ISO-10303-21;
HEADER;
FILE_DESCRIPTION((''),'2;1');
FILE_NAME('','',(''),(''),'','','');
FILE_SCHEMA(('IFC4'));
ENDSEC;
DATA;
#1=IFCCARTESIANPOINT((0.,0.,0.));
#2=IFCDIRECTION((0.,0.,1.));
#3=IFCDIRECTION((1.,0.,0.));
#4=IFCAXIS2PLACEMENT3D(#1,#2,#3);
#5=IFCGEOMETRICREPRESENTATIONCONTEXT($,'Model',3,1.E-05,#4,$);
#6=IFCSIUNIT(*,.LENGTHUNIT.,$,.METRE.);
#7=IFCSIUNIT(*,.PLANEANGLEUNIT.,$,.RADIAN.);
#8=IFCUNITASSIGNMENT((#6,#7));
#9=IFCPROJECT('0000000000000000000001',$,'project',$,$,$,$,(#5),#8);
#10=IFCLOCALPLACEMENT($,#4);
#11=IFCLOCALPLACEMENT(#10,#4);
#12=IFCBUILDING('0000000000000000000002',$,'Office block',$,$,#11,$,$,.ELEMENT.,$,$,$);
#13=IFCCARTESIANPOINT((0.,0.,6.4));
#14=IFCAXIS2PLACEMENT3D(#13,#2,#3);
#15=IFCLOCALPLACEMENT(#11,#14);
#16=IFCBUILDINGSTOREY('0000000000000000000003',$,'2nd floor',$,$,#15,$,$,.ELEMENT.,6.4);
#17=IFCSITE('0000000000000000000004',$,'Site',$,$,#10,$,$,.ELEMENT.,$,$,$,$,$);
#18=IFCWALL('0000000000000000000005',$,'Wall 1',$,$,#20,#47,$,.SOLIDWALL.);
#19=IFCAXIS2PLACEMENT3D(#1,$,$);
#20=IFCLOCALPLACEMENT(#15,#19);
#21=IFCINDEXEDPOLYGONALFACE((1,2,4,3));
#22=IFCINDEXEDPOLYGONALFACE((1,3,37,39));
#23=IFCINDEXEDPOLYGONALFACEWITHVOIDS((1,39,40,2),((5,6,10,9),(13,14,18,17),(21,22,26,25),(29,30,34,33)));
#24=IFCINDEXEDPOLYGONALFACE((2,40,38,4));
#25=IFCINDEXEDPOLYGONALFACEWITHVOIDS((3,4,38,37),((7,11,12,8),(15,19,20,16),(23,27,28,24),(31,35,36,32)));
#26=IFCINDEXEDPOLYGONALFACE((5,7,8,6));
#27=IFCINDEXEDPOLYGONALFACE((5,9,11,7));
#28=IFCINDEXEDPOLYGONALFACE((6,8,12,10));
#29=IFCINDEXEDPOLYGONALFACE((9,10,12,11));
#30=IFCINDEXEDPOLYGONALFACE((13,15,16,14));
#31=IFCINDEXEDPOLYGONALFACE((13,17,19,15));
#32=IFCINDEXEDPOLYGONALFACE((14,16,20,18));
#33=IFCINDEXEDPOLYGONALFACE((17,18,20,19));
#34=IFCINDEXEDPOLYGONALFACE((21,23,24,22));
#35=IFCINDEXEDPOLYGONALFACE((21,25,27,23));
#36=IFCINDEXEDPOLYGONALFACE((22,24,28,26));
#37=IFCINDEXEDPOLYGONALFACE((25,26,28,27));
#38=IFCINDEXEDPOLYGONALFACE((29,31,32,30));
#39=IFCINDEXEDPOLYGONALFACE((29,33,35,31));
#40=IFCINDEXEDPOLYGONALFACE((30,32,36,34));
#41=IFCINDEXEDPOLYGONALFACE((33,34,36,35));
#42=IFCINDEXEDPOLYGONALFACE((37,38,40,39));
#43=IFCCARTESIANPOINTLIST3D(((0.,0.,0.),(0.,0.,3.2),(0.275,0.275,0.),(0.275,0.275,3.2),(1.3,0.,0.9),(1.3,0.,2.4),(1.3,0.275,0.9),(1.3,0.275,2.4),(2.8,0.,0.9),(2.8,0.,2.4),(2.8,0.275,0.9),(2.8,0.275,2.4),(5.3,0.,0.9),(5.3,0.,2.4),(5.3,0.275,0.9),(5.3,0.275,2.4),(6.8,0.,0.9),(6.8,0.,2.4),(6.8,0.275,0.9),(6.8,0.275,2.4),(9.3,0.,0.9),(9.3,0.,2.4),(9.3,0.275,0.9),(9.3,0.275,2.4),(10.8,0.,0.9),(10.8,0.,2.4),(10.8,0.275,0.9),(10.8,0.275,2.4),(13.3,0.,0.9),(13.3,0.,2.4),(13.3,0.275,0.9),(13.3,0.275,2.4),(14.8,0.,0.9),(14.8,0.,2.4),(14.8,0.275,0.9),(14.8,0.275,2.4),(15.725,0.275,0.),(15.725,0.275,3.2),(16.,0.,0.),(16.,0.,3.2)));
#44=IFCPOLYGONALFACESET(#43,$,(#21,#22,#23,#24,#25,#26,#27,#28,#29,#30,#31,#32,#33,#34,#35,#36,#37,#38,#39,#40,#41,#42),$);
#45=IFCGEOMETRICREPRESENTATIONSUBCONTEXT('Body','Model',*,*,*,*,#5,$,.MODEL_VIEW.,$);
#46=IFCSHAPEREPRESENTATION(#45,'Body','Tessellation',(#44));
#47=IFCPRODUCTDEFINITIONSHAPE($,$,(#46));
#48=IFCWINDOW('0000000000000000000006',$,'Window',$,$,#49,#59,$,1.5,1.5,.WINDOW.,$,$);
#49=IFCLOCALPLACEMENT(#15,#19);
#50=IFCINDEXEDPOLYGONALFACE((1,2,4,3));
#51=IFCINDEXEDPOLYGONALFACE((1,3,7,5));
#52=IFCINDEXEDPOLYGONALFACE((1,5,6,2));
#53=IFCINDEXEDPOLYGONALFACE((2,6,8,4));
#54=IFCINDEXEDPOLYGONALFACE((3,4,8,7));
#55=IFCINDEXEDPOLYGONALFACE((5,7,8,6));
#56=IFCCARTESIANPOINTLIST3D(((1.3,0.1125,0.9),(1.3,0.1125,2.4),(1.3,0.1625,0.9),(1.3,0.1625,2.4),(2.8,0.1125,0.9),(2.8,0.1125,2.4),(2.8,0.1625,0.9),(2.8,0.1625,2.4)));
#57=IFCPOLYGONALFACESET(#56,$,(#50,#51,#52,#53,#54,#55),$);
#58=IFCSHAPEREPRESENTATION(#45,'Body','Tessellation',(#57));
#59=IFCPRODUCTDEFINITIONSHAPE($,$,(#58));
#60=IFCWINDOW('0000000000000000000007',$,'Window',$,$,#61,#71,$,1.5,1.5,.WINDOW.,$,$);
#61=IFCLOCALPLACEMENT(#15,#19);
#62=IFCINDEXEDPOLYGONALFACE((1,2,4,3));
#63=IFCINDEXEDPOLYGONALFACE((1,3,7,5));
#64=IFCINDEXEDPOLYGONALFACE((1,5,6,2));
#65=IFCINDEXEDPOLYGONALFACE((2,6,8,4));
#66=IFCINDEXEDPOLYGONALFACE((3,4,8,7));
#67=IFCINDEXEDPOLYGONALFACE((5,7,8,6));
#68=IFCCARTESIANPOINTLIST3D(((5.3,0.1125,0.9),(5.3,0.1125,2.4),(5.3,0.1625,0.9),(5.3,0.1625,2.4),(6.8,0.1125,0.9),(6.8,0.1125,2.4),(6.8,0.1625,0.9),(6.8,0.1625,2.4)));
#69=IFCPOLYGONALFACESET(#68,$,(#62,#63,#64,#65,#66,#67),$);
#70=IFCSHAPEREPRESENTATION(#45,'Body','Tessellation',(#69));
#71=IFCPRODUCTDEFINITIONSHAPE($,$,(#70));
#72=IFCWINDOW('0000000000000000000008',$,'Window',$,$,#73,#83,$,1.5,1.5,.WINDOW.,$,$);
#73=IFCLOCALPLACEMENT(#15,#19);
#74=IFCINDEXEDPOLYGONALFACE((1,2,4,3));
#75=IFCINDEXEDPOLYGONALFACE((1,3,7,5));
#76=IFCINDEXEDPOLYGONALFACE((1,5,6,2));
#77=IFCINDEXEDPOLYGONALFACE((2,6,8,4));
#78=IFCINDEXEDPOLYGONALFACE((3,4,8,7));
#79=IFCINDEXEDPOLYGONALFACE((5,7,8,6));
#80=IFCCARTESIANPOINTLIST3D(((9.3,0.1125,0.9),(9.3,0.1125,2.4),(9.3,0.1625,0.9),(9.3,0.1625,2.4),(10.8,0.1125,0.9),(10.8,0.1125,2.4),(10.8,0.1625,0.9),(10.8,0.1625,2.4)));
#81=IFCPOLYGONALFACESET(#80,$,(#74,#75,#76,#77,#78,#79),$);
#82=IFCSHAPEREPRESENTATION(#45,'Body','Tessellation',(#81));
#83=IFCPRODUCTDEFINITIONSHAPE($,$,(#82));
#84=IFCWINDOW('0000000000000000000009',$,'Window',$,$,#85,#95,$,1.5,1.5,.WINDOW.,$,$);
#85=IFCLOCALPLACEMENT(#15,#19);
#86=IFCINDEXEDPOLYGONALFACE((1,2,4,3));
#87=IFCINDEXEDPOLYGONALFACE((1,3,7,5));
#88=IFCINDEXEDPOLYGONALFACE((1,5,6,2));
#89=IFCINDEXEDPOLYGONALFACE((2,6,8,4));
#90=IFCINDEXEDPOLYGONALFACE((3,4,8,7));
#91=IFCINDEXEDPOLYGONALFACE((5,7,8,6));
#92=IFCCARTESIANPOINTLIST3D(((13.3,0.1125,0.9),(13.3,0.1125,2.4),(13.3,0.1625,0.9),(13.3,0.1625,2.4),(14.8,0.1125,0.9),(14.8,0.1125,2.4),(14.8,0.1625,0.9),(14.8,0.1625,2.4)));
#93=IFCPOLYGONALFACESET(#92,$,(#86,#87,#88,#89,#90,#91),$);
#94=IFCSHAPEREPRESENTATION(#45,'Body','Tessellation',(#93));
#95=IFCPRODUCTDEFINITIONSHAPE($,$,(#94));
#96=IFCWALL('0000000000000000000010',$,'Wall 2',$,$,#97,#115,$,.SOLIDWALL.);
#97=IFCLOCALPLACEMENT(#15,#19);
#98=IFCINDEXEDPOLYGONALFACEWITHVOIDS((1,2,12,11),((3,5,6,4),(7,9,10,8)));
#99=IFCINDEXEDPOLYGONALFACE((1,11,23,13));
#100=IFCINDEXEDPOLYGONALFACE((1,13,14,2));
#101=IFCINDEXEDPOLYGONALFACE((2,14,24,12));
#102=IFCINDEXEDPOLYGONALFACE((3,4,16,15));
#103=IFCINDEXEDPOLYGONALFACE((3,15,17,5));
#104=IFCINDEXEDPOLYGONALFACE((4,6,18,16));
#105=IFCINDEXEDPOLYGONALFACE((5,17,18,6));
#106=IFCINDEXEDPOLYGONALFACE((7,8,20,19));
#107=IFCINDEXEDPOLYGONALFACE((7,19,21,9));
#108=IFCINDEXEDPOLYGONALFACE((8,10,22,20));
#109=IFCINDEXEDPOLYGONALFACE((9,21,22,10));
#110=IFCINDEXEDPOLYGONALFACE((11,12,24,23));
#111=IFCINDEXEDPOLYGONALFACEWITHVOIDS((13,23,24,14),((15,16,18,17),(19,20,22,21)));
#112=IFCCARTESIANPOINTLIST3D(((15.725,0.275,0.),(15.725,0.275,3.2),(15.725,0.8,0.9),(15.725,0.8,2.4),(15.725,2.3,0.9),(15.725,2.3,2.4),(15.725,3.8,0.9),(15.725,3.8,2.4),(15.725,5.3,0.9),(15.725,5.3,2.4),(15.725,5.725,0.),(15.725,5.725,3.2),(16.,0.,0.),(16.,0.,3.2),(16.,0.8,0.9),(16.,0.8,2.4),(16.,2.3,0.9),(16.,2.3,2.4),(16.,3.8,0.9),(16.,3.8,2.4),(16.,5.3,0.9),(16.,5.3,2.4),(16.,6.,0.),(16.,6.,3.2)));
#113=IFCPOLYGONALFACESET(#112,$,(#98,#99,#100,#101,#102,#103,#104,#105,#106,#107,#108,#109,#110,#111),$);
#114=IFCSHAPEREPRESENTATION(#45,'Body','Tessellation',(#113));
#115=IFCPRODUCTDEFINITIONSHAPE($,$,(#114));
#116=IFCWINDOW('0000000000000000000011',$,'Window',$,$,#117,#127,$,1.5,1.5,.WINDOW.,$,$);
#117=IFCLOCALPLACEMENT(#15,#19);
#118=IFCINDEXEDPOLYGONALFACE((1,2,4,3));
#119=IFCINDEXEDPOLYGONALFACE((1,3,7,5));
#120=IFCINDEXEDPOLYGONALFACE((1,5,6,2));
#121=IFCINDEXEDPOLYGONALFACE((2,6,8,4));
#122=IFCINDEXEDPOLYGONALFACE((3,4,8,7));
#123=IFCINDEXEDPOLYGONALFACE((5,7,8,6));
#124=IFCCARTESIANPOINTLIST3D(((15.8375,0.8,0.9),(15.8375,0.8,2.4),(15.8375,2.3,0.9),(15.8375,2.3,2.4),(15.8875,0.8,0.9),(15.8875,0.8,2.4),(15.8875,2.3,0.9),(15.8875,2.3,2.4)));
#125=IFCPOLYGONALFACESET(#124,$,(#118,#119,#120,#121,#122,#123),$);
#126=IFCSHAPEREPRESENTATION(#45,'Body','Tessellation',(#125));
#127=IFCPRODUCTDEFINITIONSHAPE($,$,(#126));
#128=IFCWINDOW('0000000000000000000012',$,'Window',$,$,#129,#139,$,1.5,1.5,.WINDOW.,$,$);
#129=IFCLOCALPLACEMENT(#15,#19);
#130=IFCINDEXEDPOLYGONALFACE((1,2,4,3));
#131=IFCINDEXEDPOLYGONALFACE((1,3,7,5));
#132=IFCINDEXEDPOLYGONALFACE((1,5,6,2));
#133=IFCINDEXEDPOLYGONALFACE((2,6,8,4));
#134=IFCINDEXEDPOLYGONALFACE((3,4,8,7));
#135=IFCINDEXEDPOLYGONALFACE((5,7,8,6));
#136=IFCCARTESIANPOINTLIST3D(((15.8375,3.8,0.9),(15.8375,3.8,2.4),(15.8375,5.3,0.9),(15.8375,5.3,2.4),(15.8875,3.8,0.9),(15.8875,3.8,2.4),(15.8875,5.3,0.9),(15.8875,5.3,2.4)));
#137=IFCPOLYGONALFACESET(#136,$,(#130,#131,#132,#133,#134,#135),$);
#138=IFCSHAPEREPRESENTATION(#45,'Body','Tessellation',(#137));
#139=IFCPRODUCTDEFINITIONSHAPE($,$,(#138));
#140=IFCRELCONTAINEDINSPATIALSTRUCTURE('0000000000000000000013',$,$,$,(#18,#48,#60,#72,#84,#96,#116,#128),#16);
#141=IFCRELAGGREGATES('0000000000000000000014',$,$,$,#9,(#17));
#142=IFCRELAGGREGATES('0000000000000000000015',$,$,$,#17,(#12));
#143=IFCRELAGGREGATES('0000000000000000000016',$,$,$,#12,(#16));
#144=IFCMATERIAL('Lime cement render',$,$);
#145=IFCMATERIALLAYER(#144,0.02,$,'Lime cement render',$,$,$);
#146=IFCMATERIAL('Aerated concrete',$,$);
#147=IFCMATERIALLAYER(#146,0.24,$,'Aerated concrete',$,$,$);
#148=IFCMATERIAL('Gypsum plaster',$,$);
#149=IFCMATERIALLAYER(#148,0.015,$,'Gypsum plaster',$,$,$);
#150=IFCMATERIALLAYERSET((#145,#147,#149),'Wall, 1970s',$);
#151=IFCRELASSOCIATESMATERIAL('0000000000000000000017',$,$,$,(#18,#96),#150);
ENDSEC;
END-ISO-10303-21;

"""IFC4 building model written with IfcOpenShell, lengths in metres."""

from ifc_helpers import new_model, si_unit, frame, origin_with_axes, place, context, subcontext, project, spatial, polyline, outline, extrude, material, layer, layer_set, layer_usage, element, fill, save


model = new_model("IFC4")

# Units and contexts
model_context = context("Model", 3, precision=1e-05, world=origin_with_axes())
body_context = subcontext(model_context, "Body", "Model", "MODEL_VIEW")
ifc_project = project(units=[si_unit("LENGTHUNIT", "METRE"), si_unit("PLANEANGLEUNIT", "RADIAN")], contexts=[model_context])

# Site, building, storey
site_placement = place(None, origin_with_axes())
site = spatial("IfcSite", under=ifc_project, at=site_placement, Name="Site", CompositionType="ELEMENT")
building_placement = place(site_placement, origin_with_axes())
building = spatial("IfcBuilding", under=site, at=building_placement, Name="Office block", CompositionType="ELEMENT")
storey_placement = place(building_placement, frame((0.0, 0.0, 6.4), z_axis=(0.0, 0.0, 1.0), x_axis=(1.0, 0.0, 0.0)))
storey = spatial("IfcBuildingStorey", under=building, at=storey_placement, Name="2nd floor", CompositionType="ELEMENT", Elevation=6.4)

# Walls, openings, windows
ifc_material_1 = material(Name="Lime cement render")
ifc_layer_1 = layer(ifc_material_1, 0.02, Name="Lime cement render")
ifc_material_2 = material(Name="Aerated concrete")
ifc_layer_2 = layer(ifc_material_2, 0.24, Name="Aerated concrete")
ifc_material_3 = material(Name="Gypsum plaster")
ifc_layer_3 = layer(ifc_material_3, 0.015, Name="Gypsum plaster")
ifc_layer_set = layer_set([ifc_layer_1, ifc_layer_2, ifc_layer_3], Name="Wall, 1970s")
ifc_layer_usage_1 = layer_usage(ifc_layer_set, "AXIS2", "NEGATIVE", 0.0)
wall_1_placement = place(storey_placement, origin_with_axes())
wall_1 = element("IfcWall", 1, at=wall_1_placement, inside=storey, material=ifc_layer_usage_1, Name="Wall 1", PredefinedType="SOLIDWALL", context=body_context, shape_type="SweptSolid", body=[
    extrude(outline(polyline([(0.0, 0.0), (16.0, 0.0), (15.725, 0.275), (0.275, 0.275), (0.0, 0.0)])), origin_with_axes(), (0.0, 0.0, 1.0), 3.2),
])
opening_1_placement = place(storey_placement, origin_with_axes())
opening_1 = element("IfcOpeningElement", 2, at=opening_1_placement, cuts=wall_1, PredefinedType="OPENING", context=body_context, shape_type="SweptSolid", body=[
    extrude(outline(polyline([(1.3, -0.01), (2.8, -0.01), (2.8, 0.285), (1.3, 0.285), (1.3, -0.01)])), frame((0.0, 0.0, 0.9), z_axis=(0.0, 0.0, 1.0), x_axis=(1.0, 0.0, 0.0)), (0.0, 0.0, 1.0), 1.5),
])
opening_2_placement = place(storey_placement, origin_with_axes())
opening_2 = element("IfcOpeningElement", 3, at=opening_2_placement, cuts=wall_1, PredefinedType="OPENING", context=body_context, shape_type="SweptSolid", body=[
    extrude(outline(polyline([(5.3, -0.01), (6.8, -0.01), (6.8, 0.285), (5.3, 0.285), (5.3, -0.01)])), frame((0.0, 0.0, 0.9), z_axis=(0.0, 0.0, 1.0), x_axis=(1.0, 0.0, 0.0)), (0.0, 0.0, 1.0), 1.5),
])
opening_3_placement = place(storey_placement, origin_with_axes())
opening_3 = element("IfcOpeningElement", 4, at=opening_3_placement, cuts=wall_1, PredefinedType="OPENING", context=body_context, shape_type="SweptSolid", body=[
    extrude(outline(polyline([(9.3, -0.01), (10.8, -0.01), (10.8, 0.285), (9.3, 0.285), (9.3, -0.01)])), frame((0.0, 0.0, 0.9), z_axis=(0.0, 0.0, 1.0), x_axis=(1.0, 0.0, 0.0)), (0.0, 0.0, 1.0), 1.5),
])
opening_4_placement = place(storey_placement, origin_with_axes())
opening_4 = element("IfcOpeningElement", 5, at=opening_4_placement, cuts=wall_1, PredefinedType="OPENING", context=body_context, shape_type="SweptSolid", body=[
    extrude(outline(polyline([(13.3, -0.01), (14.8, -0.01), (14.8, 0.285), (13.3, 0.285), (13.3, -0.01)])), frame((0.0, 0.0, 0.9), z_axis=(0.0, 0.0, 1.0), x_axis=(1.0, 0.0, 0.0)), (0.0, 0.0, 1.0), 1.5),
])
window_1_placement = place(storey_placement, origin_with_axes())
window_1 = element("IfcWindow", 6, at=window_1_placement, inside=storey, Name="Window", OverallHeight=1.5, OverallWidth=1.5, PredefinedType="WINDOW", context=body_context, shape_type="SweptSolid", body=[
    extrude(outline(polyline([(1.3, 0.1125), (2.8, 0.1125), (2.8, 0.1625), (1.3, 0.1625), (1.3, 0.1125)])), frame((0.0, 0.0, 0.9), z_axis=(0.0, 0.0, 1.0), x_axis=(1.0, 0.0, 0.0)), (0.0, 0.0, 1.0), 1.5),
])
fill(opening_1, window_1)
window_2_placement = place(storey_placement, origin_with_axes())
window_2 = element("IfcWindow", 7, at=window_2_placement, inside=storey, Name="Window", OverallHeight=1.5, OverallWidth=1.5, PredefinedType="WINDOW", context=body_context, shape_type="SweptSolid", body=[
    extrude(outline(polyline([(5.3, 0.1125), (6.8, 0.1125), (6.8, 0.1625), (5.3, 0.1625), (5.3, 0.1125)])), frame((0.0, 0.0, 0.9), z_axis=(0.0, 0.0, 1.0), x_axis=(1.0, 0.0, 0.0)), (0.0, 0.0, 1.0), 1.5),
])
fill(opening_2, window_2)
window_3_placement = place(storey_placement, origin_with_axes())
window_3 = element("IfcWindow", 8, at=window_3_placement, inside=storey, Name="Window", OverallHeight=1.5, OverallWidth=1.5, PredefinedType="WINDOW", context=body_context, shape_type="SweptSolid", body=[
    extrude(outline(polyline([(9.3, 0.1125), (10.8, 0.1125), (10.8, 0.1625), (9.3, 0.1625), (9.3, 0.1125)])), frame((0.0, 0.0, 0.9), z_axis=(0.0, 0.0, 1.0), x_axis=(1.0, 0.0, 0.0)), (0.0, 0.0, 1.0), 1.5),
])
fill(opening_3, window_3)
window_4_placement = place(storey_placement, origin_with_axes())
window_4 = element("IfcWindow", 9, at=window_4_placement, inside=storey, Name="Window", OverallHeight=1.5, OverallWidth=1.5, PredefinedType="WINDOW", context=body_context, shape_type="SweptSolid", body=[
    extrude(outline(polyline([(13.3, 0.1125), (14.8, 0.1125), (14.8, 0.1625), (13.3, 0.1625), (13.3, 0.1125)])), frame((0.0, 0.0, 0.9), z_axis=(0.0, 0.0, 1.0), x_axis=(1.0, 0.0, 0.0)), (0.0, 0.0, 1.0), 1.5),
])
fill(opening_4, window_4)
ifc_layer_usage_2 = layer_usage(ifc_layer_set, "AXIS2", "NEGATIVE", 0.0)
wall_2_placement = place(storey_placement, origin_with_axes())
wall_2 = element("IfcWall", 10, at=wall_2_placement, inside=storey, material=ifc_layer_usage_2, Name="Wall 2", PredefinedType="SOLIDWALL", context=body_context, shape_type="SweptSolid", body=[
    extrude(outline(polyline([(16.0, 0.0), (16.0, 6.0), (15.725, 5.725), (15.725, 0.275), (16.0, 0.0)])), origin_with_axes(), (0.0, 0.0, 1.0), 3.2),
])
opening_5_placement = place(storey_placement, origin_with_axes())
opening_5 = element("IfcOpeningElement", 11, at=opening_5_placement, cuts=wall_2, PredefinedType="OPENING", context=body_context, shape_type="SweptSolid", body=[
    extrude(outline(polyline([(16.01, 0.8), (16.01, 2.3), (15.715, 2.3), (15.715, 0.8), (16.01, 0.8)])), frame((0.0, 0.0, 0.9), z_axis=(0.0, 0.0, 1.0), x_axis=(1.0, 0.0, 0.0)), (0.0, 0.0, 1.0), 1.5),
])
opening_6_placement = place(storey_placement, origin_with_axes())
opening_6 = element("IfcOpeningElement", 12, at=opening_6_placement, cuts=wall_2, PredefinedType="OPENING", context=body_context, shape_type="SweptSolid", body=[
    extrude(outline(polyline([(16.01, 3.8), (16.01, 5.3), (15.715, 5.3), (15.715, 3.8), (16.01, 3.8)])), frame((0.0, 0.0, 0.9), z_axis=(0.0, 0.0, 1.0), x_axis=(1.0, 0.0, 0.0)), (0.0, 0.0, 1.0), 1.5),
])
window_5_placement = place(storey_placement, origin_with_axes())
window_5 = element("IfcWindow", 13, at=window_5_placement, inside=storey, Name="Window", OverallHeight=1.5, OverallWidth=1.5, PredefinedType="WINDOW", context=body_context, shape_type="SweptSolid", body=[
    extrude(outline(polyline([(15.8875, 0.8), (15.8875, 2.3), (15.8375, 2.3), (15.8375, 0.8), (15.8875, 0.8)])), frame((0.0, 0.0, 0.9), z_axis=(0.0, 0.0, 1.0), x_axis=(1.0, 0.0, 0.0)), (0.0, 0.0, 1.0), 1.5),
])
fill(opening_5, window_5)
window_6_placement = place(storey_placement, origin_with_axes())
window_6 = element("IfcWindow", 14, at=window_6_placement, inside=storey, Name="Window", OverallHeight=1.5, OverallWidth=1.5, PredefinedType="WINDOW", context=body_context, shape_type="SweptSolid", body=[
    extrude(outline(polyline([(15.8875, 3.8), (15.8875, 5.3), (15.8375, 5.3), (15.8375, 3.8), (15.8875, 3.8)])), frame((0.0, 0.0, 0.9), z_axis=(0.0, 0.0, 1.0), x_axis=(1.0, 0.0, 0.0)), (0.0, 0.0, 1.0), 1.5),
])
fill(opening_6, window_6)

save(model, "model.ifc")
